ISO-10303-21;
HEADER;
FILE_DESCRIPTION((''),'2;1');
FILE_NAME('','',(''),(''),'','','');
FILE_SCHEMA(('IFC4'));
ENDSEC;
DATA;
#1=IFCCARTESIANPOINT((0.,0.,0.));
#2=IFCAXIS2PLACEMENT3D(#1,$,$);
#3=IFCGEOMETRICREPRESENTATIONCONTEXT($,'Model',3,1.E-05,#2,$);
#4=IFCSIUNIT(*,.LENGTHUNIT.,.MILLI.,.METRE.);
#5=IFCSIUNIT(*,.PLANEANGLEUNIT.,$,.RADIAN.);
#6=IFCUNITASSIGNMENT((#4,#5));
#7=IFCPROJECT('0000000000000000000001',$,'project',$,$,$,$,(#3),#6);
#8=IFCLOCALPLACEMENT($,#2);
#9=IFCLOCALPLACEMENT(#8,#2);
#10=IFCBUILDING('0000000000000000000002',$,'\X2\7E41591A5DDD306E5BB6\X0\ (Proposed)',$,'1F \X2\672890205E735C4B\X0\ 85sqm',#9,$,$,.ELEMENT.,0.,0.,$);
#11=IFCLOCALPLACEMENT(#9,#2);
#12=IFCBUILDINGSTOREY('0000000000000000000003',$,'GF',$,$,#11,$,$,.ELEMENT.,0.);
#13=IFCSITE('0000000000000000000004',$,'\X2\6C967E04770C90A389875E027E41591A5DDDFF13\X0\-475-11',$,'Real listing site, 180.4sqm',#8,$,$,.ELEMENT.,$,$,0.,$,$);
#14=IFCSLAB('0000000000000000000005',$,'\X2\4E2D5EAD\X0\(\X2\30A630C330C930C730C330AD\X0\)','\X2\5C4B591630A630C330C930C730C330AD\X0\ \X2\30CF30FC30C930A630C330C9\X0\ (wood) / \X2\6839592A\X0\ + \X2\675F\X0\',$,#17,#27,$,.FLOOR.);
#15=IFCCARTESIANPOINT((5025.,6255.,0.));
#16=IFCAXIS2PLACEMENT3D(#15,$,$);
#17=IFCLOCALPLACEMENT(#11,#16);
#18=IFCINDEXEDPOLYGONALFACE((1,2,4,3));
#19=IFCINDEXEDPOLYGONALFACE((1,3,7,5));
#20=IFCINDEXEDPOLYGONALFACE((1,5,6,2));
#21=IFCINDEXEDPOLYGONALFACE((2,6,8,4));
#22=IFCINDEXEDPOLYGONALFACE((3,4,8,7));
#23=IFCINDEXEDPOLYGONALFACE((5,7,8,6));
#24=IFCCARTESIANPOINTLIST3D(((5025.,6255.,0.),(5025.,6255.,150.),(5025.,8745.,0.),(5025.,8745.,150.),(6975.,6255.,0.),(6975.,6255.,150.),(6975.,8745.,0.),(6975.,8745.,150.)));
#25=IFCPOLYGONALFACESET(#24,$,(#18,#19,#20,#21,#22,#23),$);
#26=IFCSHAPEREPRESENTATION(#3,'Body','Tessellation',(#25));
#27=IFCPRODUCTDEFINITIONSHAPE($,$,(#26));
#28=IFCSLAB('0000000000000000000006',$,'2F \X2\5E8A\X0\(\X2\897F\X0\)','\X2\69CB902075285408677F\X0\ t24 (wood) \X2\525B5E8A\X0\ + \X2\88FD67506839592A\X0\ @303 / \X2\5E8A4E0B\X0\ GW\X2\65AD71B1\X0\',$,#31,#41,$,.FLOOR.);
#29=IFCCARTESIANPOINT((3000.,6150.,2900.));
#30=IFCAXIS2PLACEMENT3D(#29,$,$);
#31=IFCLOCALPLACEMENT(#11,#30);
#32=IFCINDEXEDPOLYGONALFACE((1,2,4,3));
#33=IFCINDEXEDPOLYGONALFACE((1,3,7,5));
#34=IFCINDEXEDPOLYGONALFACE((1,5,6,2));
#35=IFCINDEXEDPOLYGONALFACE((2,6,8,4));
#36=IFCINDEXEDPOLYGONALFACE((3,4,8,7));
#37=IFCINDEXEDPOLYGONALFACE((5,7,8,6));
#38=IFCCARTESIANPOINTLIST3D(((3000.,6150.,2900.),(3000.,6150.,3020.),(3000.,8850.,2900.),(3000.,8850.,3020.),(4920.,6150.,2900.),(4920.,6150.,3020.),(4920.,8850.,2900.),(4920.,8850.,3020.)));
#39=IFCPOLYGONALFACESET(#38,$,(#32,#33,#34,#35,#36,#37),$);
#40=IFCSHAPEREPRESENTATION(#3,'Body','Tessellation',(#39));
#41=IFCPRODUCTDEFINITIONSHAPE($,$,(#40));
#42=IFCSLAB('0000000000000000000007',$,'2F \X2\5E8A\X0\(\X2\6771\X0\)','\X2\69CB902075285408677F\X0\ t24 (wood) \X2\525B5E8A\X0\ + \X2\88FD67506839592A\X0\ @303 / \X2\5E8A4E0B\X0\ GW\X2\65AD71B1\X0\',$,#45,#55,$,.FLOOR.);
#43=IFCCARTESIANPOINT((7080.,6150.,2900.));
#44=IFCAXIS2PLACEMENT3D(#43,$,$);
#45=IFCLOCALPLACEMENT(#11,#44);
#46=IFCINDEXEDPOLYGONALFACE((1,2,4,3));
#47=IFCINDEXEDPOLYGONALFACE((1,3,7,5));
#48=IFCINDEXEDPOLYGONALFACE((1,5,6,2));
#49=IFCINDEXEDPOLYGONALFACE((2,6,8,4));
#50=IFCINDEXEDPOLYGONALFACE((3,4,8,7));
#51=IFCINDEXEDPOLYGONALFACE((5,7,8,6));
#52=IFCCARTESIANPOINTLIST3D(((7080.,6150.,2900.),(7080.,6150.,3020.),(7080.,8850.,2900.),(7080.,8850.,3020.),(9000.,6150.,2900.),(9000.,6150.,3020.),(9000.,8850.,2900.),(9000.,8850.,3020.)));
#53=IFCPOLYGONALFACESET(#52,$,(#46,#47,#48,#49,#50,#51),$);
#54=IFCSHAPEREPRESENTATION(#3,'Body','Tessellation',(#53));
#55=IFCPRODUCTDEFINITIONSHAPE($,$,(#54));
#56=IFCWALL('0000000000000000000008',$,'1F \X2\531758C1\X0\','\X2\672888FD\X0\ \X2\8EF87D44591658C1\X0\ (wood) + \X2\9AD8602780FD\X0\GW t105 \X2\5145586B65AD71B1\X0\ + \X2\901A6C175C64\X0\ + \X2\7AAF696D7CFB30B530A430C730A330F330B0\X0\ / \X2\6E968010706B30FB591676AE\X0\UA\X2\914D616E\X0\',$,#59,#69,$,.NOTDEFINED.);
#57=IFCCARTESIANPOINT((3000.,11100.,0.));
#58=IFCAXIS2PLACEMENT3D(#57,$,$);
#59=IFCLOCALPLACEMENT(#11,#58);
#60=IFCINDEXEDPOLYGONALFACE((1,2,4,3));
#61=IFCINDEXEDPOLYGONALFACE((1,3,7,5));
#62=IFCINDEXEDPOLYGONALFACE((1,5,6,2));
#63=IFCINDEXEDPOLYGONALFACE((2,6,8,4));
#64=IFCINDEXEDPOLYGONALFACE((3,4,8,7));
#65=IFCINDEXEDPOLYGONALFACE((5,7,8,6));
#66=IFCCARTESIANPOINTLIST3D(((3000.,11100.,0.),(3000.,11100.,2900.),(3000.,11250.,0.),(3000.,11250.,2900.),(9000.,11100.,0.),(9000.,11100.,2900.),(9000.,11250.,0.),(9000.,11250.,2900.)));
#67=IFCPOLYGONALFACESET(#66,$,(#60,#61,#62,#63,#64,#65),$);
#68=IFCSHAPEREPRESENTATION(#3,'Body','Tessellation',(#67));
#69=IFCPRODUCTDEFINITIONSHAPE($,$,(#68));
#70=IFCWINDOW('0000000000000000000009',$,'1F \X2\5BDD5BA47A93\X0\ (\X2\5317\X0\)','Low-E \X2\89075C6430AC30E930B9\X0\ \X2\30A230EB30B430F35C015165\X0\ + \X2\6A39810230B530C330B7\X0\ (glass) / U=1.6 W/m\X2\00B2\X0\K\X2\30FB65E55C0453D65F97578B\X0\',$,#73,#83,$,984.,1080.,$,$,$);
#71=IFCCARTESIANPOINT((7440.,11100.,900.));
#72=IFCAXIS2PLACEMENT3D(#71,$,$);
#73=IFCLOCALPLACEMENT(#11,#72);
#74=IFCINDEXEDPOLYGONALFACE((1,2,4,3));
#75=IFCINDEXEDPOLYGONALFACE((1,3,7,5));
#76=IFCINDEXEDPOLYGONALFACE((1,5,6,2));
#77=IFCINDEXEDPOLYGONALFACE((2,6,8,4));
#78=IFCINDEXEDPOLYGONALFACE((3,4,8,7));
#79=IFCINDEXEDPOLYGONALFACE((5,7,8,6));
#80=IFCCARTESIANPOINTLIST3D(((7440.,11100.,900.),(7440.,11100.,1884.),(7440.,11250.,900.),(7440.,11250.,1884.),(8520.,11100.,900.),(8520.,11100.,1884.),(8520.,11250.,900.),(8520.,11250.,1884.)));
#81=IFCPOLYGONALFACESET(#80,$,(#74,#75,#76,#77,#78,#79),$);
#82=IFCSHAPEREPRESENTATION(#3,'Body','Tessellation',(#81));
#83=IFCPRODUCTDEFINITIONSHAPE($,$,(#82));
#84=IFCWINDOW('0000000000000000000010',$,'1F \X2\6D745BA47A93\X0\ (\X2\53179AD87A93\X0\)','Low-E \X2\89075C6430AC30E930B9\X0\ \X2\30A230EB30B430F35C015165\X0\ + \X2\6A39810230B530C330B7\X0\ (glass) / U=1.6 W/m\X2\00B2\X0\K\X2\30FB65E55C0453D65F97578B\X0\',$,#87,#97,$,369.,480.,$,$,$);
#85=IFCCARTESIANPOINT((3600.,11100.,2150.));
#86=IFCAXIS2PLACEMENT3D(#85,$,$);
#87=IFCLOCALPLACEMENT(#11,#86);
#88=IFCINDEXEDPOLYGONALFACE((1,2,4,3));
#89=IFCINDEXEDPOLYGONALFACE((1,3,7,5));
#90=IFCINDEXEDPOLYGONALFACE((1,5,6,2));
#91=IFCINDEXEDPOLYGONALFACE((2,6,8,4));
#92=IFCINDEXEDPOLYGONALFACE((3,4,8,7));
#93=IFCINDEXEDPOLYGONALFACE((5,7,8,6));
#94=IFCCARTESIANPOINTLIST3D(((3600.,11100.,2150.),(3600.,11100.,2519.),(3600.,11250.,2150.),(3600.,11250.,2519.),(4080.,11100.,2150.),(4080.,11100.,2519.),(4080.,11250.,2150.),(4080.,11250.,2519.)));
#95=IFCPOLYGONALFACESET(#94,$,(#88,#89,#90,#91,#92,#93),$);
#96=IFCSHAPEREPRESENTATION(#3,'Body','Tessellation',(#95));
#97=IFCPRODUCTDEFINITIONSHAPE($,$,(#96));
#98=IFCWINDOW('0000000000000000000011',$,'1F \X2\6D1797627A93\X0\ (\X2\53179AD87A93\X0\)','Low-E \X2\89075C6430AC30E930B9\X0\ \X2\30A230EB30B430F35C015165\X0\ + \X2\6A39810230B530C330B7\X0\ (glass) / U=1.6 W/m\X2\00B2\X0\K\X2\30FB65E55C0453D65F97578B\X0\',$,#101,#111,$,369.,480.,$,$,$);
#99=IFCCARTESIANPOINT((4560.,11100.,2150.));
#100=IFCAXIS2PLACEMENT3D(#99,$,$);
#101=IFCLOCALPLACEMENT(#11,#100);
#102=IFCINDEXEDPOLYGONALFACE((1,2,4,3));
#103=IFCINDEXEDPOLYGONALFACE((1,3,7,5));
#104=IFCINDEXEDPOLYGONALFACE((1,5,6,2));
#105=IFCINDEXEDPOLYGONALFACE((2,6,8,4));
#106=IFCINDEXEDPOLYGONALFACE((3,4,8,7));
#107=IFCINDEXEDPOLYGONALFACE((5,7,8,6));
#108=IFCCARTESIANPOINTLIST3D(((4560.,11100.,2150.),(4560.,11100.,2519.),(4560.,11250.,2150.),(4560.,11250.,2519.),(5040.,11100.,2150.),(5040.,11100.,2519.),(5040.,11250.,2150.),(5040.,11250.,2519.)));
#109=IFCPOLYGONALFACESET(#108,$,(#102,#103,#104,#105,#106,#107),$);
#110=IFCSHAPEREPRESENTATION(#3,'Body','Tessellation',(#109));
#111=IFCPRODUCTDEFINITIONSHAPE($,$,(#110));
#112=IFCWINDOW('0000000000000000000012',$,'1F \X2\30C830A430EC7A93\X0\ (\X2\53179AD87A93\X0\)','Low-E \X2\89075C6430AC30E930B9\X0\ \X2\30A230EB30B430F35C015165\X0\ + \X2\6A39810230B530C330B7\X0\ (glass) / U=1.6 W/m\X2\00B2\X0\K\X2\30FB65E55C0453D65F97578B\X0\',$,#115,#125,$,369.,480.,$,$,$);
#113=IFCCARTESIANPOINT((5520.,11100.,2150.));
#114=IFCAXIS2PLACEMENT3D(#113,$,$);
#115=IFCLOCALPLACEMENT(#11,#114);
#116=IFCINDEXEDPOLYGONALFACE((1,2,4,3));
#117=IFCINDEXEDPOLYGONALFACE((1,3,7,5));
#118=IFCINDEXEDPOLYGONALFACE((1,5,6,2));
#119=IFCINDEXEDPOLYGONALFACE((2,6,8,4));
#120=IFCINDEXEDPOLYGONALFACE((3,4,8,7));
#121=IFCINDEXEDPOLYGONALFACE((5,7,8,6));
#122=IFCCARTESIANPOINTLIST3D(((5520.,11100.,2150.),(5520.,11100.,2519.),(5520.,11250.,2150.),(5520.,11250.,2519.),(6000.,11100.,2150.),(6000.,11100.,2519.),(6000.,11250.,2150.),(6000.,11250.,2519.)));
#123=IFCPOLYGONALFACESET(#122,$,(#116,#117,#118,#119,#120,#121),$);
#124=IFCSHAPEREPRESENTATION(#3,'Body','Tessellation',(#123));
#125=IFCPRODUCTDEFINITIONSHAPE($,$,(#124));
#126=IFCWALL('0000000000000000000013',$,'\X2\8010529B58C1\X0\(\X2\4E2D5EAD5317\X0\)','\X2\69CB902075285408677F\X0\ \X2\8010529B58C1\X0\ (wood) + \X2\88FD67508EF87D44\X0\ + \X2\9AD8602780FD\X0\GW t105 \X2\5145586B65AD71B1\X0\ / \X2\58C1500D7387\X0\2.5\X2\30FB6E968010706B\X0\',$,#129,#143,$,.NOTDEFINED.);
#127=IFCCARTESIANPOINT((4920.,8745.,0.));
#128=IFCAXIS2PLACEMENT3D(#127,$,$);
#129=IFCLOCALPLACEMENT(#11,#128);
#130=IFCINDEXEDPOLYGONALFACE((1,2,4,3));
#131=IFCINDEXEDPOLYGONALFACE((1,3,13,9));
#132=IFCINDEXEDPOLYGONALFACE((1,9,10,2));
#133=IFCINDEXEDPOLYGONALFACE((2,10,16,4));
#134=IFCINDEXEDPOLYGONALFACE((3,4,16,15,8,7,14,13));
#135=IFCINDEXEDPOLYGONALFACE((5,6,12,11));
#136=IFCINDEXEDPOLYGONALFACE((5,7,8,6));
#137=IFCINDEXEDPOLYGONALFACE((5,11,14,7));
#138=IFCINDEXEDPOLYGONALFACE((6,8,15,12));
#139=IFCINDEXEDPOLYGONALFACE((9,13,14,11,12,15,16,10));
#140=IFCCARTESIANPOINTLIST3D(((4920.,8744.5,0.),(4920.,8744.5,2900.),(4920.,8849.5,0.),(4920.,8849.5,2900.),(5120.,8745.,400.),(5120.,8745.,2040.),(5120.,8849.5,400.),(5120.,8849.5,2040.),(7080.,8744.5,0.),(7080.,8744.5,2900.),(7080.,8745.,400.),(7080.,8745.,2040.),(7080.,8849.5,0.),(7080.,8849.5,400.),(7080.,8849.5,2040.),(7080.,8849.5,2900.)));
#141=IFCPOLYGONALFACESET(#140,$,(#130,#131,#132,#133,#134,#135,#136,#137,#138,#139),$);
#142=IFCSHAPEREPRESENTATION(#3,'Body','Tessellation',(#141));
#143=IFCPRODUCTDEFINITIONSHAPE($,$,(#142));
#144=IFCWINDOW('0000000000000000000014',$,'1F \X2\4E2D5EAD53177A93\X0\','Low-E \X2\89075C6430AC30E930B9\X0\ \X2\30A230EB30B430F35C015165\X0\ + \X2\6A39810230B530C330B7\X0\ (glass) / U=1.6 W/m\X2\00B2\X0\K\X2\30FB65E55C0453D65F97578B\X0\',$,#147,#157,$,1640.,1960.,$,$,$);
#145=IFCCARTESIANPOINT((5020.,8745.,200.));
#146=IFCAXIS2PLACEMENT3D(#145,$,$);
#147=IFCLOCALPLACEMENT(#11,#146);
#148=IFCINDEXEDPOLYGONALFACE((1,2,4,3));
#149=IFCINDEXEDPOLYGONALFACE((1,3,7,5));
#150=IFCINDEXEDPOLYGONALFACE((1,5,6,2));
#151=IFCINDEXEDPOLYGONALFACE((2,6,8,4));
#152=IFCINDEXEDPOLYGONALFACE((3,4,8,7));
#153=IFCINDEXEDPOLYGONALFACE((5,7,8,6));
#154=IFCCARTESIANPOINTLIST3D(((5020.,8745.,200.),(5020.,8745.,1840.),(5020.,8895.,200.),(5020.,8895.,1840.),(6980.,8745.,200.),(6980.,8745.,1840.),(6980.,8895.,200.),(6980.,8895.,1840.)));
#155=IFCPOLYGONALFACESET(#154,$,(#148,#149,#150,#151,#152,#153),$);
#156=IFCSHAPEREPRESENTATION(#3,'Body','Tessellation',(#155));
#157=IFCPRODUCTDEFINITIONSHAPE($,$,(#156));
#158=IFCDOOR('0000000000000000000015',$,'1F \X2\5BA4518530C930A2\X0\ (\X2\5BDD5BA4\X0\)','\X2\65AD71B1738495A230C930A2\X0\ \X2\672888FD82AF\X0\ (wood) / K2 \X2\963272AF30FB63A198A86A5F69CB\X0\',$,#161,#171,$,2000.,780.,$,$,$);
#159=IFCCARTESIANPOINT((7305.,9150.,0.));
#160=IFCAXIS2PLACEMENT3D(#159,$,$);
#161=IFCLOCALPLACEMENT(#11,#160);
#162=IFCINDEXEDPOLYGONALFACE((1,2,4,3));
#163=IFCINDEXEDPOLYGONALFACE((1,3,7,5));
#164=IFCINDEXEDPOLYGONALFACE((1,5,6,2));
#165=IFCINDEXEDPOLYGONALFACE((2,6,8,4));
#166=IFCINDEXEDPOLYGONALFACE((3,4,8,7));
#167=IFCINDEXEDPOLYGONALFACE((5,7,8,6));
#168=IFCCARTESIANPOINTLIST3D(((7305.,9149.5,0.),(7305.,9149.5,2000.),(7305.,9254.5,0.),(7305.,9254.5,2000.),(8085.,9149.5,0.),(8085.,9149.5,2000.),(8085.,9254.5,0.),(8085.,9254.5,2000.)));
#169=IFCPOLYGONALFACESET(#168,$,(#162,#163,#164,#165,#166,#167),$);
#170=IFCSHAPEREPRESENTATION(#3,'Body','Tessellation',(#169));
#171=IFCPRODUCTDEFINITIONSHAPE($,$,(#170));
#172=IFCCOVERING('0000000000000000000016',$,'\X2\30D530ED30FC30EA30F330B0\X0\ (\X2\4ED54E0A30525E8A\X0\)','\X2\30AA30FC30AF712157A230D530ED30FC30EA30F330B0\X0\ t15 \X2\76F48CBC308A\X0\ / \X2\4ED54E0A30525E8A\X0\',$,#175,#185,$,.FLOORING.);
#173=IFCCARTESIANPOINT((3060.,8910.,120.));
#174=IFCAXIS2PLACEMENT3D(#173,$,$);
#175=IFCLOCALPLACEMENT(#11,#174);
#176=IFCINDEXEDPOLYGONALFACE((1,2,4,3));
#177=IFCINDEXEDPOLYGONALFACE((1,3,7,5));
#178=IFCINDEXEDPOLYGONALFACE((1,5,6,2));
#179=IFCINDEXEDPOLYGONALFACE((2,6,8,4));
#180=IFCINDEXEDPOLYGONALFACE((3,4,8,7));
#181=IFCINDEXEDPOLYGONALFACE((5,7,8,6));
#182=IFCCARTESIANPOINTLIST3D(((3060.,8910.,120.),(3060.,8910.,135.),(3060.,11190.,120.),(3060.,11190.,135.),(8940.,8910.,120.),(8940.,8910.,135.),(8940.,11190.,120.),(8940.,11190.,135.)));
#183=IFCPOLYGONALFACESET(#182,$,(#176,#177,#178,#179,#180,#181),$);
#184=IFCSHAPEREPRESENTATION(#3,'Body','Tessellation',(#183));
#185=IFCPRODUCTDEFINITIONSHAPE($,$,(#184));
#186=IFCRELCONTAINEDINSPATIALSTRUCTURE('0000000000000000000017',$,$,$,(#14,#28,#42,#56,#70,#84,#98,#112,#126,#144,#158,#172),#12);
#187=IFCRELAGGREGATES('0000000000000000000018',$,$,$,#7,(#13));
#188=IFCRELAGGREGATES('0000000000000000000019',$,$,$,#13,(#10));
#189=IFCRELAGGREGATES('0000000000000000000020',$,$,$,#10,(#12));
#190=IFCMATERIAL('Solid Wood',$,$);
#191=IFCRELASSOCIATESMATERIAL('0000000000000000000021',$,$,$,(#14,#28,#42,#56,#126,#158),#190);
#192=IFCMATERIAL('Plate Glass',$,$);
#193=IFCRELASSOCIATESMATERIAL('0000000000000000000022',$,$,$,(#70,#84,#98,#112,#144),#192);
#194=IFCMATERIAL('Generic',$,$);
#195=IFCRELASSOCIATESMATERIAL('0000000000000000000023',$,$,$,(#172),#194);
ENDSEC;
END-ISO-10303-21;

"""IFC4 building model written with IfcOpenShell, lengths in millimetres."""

from ifc_helpers import new_model, si_unit, frame, frame_2d, origin, place, context, project, spatial, rectangle, extrude, material, element, fill, save


model = new_model("IFC4")

# Units and contexts
model_context = context("Model", 3, precision=1e-05, world=origin())
ifc_project = project(units=[si_unit("LENGTHUNIT", "METRE", prefix="MILLI"), si_unit("PLANEANGLEUNIT", "RADIAN")], contexts=[model_context])

# Site, building, storey
site_placement = place(None, origin())
site = spatial("IfcSite", under=ifc_project, at=site_placement, Name="沖縄県那覇市繁多川３-475-11", ObjectType="Real listing site, 180.4sqm", CompositionType="ELEMENT", RefElevation=0.0)
building_placement = place(site_placement, origin())
building = spatial("IfcBuilding", under=site, at=building_placement, Name="繁多川の家 (Proposed)", ObjectType="1F 木造平屋 85sqm", CompositionType="ELEMENT", ElevationOfRefHeight=0.0, ElevationOfTerrain=0.0)
storey_placement = place(building_placement, origin())
storey = spatial("IfcBuildingStorey", under=building, at=storey_placement, Name="GF", CompositionType="ELEMENT", Elevation=0.0)

# Slabs
ifc_material_1 = material(Name="Solid Wood")
slab_1_placement = place(storey_placement, frame((5025.0, 6255.0, 0.0)))
element("IfcSlab", 1, at=slab_1_placement, inside=storey, material=ifc_material_1, Name="中庭(ウッドデッキ)", Description="屋外ウッドデッキ ハードウッド (wood) / 根太 + 束", PredefinedType="FLOOR", context=model_context, shape_type="SweptSolid", body=[
    extrude(rectangle(XDim=1950.0, YDim=2490.0, at=frame_2d((975.0, 1245.0))), frame((5025.0, 6255.0, 0.0)), (0.0, 0.0, 1.0), 150.0),
])
slab_2_placement = place(storey_placement, frame((3000.0, 6150.0, 2900.0)))
element("IfcSlab", 2, at=slab_2_placement, inside=storey, material=ifc_material_1, Name="2F 床(西)", Description="構造用合板 t24 (wood) 剛床 + 製材根太 @303 / 床下 GW断熱", PredefinedType="FLOOR", context=model_context, shape_type="SweptSolid", body=[
    extrude(rectangle(XDim=1920.0, YDim=2700.0, at=frame_2d((960.0, 1350.0))), frame((3000.0, 6150.0, 2900.0)), (0.0, 0.0, 1.0), 120.0),
])
slab_3_placement = place(storey_placement, frame((7080.0, 6150.0, 2900.0)))
element("IfcSlab", 3, at=slab_3_placement, inside=storey, material=ifc_material_1, Name="2F 床(東)", Description="構造用合板 t24 (wood) 剛床 + 製材根太 @303 / 床下 GW断熱", PredefinedType="FLOOR", context=model_context, shape_type="SweptSolid", body=[
    extrude(rectangle(XDim=1920.0, YDim=2700.0, at=frame_2d((960.0, 1350.0))), frame((7080.0, 6150.0, 2900.0)), (0.0, 0.0, 1.0), 120.0),
])

# Wall, openings, windows
wall_1_placement = place(storey_placement, frame((3000.0, 11100.0, 0.0)))
wall_1 = element("IfcWall", 4, at=wall_1_placement, inside=storey, material=ifc_material_1, Name="1F 北壁", Description="木製 軸組外壁 (wood) + 高性能GW t105 充填断熱 + 通気層 + 窯業系サイディング / 準耐火・外皮UA配慮", PredefinedType="NOTDEFINED", context=model_context, shape_type="SweptSolid", body=[
    extrude(rectangle(XDim=6000.0, YDim=150.0, at=frame_2d((3000.0, 75.0))), frame((3000.0, 11100.0, 0.0)), (0.0, 0.0, 1.0), 2900.0),
])
opening_1_placement = place(storey_placement, frame((7440.0, 11100.0, 900.0)))
opening_1 = element("IfcOpeningElement", 5, at=opening_1_placement, cuts=wall_1, PredefinedType="NOTDEFINED", context=model_context, shape_type="SweptSolid", body=[
    extrude(rectangle(XDim=1080.0, YDim=150.0, at=frame_2d((540.0, 75.0))), frame((7440.0, 11100.0, 900.0)), (0.0, 0.0, 1.0), 984.0),
])
opening_2_placement = place(storey_placement, frame((3600.0, 11100.0, 2150.0)))
opening_2 = element("IfcOpeningElement", 6, at=opening_2_placement, cuts=wall_1, PredefinedType="NOTDEFINED", context=model_context, shape_type="SweptSolid", body=[
    extrude(rectangle(XDim=480.0, YDim=150.0, at=frame_2d((240.0, 75.0))), frame((3600.0, 11100.0, 2150.0)), (0.0, 0.0, 1.0), 369.0),
])
opening_3_placement = place(storey_placement, frame((4560.0, 11100.0, 2150.0)))
opening_3 = element("IfcOpeningElement", 7, at=opening_3_placement, cuts=wall_1, PredefinedType="NOTDEFINED", context=model_context, shape_type="SweptSolid", body=[
    extrude(rectangle(XDim=480.0, YDim=150.0, at=frame_2d((240.0, 75.0))), frame((4560.0, 11100.0, 2150.0)), (0.0, 0.0, 1.0), 369.0),
])
opening_4_placement = place(storey_placement, frame((5520.0, 11100.0, 2150.0)))
opening_4 = element("IfcOpeningElement", 8, at=opening_4_placement, cuts=wall_1, PredefinedType="NOTDEFINED", context=model_context, shape_type="SweptSolid", body=[
    extrude(rectangle(XDim=480.0, YDim=150.0, at=frame_2d((240.0, 75.0))), frame((5520.0, 11100.0, 2150.0)), (0.0, 0.0, 1.0), 369.0),
])
ifc_material_2 = material(Name="Plate Glass")
window_1_placement = place(storey_placement, frame((7440.0, 11100.0, 900.0)))
window_1 = element("IfcWindow", 9, at=window_1_placement, inside=storey, material=ifc_material_2, Name="1F 寝室窓 (北)", Description="Low-E 複層ガラス アルゴン封入 + 樹脂サッシ (glass) / U=1.6 W/m²K・日射取得型", OverallHeight=984.0, OverallWidth=1080.0, context=model_context, shape_type="SweptSolid", body=[
    extrude(rectangle(XDim=1080.0, YDim=150.0, at=frame_2d((540.0, 75.0))), frame((7440.0, 11100.0, 900.0)), (0.0, 0.0, 1.0), 984.0),
])
fill(opening_1, window_1)
window_2_placement = place(storey_placement, frame((3600.0, 11100.0, 2150.0)))
window_2 = element("IfcWindow", 10, at=window_2_placement, inside=storey, material=ifc_material_2, Name="1F 浴室窓 (北高窓)", Description="Low-E 複層ガラス アルゴン封入 + 樹脂サッシ (glass) / U=1.6 W/m²K・日射取得型", OverallHeight=369.0, OverallWidth=480.0, context=model_context, shape_type="SweptSolid", body=[
    extrude(rectangle(XDim=480.0, YDim=150.0, at=frame_2d((240.0, 75.0))), frame((3600.0, 11100.0, 2150.0)), (0.0, 0.0, 1.0), 369.0),
])
fill(opening_2, window_2)
window_3_placement = place(storey_placement, frame((4560.0, 11100.0, 2150.0)))
window_3 = element("IfcWindow", 11, at=window_3_placement, inside=storey, material=ifc_material_2, Name="1F 洗面窓 (北高窓)", Description="Low-E 複層ガラス アルゴン封入 + 樹脂サッシ (glass) / U=1.6 W/m²K・日射取得型", OverallHeight=369.0, OverallWidth=480.0, context=model_context, shape_type="SweptSolid", body=[
    extrude(rectangle(XDim=480.0, YDim=150.0, at=frame_2d((240.0, 75.0))), frame((4560.0, 11100.0, 2150.0)), (0.0, 0.0, 1.0), 369.0),
])
fill(opening_3, window_3)
window_4_placement = place(storey_placement, frame((5520.0, 11100.0, 2150.0)))
window_4 = element("IfcWindow", 12, at=window_4_placement, inside=storey, material=ifc_material_2, Name="1F トイレ窓 (北高窓)", Description="Low-E 複層ガラス アルゴン封入 + 樹脂サッシ (glass) / U=1.6 W/m²K・日射取得型", OverallHeight=369.0, OverallWidth=480.0, context=model_context, shape_type="SweptSolid", body=[
    extrude(rectangle(XDim=480.0, YDim=150.0, at=frame_2d((240.0, 75.0))), frame((5520.0, 11100.0, 2150.0)), (0.0, 0.0, 1.0), 369.0),
])
fill(opening_4, window_4)

# Wall, opening, window
wall_2_placement = place(storey_placement, frame((4920.0, 8745.0, 0.0)))
wall_2 = element("IfcWall", 13, at=wall_2_placement, inside=storey, material=ifc_material_1, Name="耐力壁(中庭北)", Description="構造用合板 耐力壁 (wood) + 製材軸組 + 高性能GW t105 充填断熱 / 壁倍率2.5・準耐火", PredefinedType="NOTDEFINED", context=model_context, shape_type="SweptSolid", body=[
    extrude(rectangle(XDim=2160.0, YDim=105.0, at=frame_2d((1080.0, 52.0))), frame((4920.0, 8745.0, 0.0)), (0.0, 0.0, 1.0), 2900.0),
])
opening_5_placement = place(storey_placement, frame((5020.0, 8745.0, 200.0)))
opening_5 = element("IfcOpeningElement", 14, at=opening_5_placement, cuts=wall_2, PredefinedType="NOTDEFINED", context=model_context, shape_type="SweptSolid", body=[
    extrude(rectangle(XDim=1960.0, YDim=150.0, at=frame_2d((980.0, 75.0))), frame((5020.0, 8745.0, 200.0)), (0.0, 0.0, 1.0), 1640.0),
])
window_5_placement = place(storey_placement, frame((5020.0, 8745.0, 200.0)))
window_5 = element("IfcWindow", 15, at=window_5_placement, inside=storey, material=ifc_material_2, Name="1F 中庭北窓", Description="Low-E 複層ガラス アルゴン封入 + 樹脂サッシ (glass) / U=1.6 W/m²K・日射取得型", OverallHeight=1640.0, OverallWidth=1960.0, context=model_context, shape_type="SweptSolid", body=[
    extrude(rectangle(XDim=1960.0, YDim=150.0, at=frame_2d((980.0, 75.0))), frame((5020.0, 8745.0, 200.0)), (0.0, 0.0, 1.0), 1640.0),
])
fill(opening_5, window_5)

# Door
door_1_placement = place(storey_placement, frame((7305.0, 9150.0, 0.0)))
element("IfcDoor", 16, at=door_1_placement, inside=storey, material=ifc_material_1, Name="1F 室内ドア (寝室)", Description="断熱玄関ドア 木製芯 (wood) / K2 防犯・採風機構", OverallHeight=2000.0, OverallWidth=780.0, context=model_context, shape_type="SweptSolid", body=[
    extrude(rectangle(XDim=780.0, YDim=105.0, at=frame_2d((390.0, 52.0))), frame((7305.0, 9150.0, 0.0)), (0.0, 0.0, 1.0), 2000.0),
])

# Covering
ifc_material_3 = material(Name="Generic")
covering_1_placement = place(storey_placement, frame((3060.0, 8910.0, 120.0)))
element("IfcCovering", 17, at=covering_1_placement, inside=storey, material=ifc_material_3, Name="フローリング (仕上げ床)", Description="オーク無垢フローリング t15 直貼り / 仕上げ床", PredefinedType="FLOORING", context=model_context, shape_type="SweptSolid", body=[
    extrude(rectangle(XDim=5880.0, YDim=2280.0, at=frame_2d((2940.0, 1140.0))), frame((3060.0, 8910.0, 120.0)), (0.0, 0.0, 1.0), 15.0),
])

save(model, "model.ifc")
